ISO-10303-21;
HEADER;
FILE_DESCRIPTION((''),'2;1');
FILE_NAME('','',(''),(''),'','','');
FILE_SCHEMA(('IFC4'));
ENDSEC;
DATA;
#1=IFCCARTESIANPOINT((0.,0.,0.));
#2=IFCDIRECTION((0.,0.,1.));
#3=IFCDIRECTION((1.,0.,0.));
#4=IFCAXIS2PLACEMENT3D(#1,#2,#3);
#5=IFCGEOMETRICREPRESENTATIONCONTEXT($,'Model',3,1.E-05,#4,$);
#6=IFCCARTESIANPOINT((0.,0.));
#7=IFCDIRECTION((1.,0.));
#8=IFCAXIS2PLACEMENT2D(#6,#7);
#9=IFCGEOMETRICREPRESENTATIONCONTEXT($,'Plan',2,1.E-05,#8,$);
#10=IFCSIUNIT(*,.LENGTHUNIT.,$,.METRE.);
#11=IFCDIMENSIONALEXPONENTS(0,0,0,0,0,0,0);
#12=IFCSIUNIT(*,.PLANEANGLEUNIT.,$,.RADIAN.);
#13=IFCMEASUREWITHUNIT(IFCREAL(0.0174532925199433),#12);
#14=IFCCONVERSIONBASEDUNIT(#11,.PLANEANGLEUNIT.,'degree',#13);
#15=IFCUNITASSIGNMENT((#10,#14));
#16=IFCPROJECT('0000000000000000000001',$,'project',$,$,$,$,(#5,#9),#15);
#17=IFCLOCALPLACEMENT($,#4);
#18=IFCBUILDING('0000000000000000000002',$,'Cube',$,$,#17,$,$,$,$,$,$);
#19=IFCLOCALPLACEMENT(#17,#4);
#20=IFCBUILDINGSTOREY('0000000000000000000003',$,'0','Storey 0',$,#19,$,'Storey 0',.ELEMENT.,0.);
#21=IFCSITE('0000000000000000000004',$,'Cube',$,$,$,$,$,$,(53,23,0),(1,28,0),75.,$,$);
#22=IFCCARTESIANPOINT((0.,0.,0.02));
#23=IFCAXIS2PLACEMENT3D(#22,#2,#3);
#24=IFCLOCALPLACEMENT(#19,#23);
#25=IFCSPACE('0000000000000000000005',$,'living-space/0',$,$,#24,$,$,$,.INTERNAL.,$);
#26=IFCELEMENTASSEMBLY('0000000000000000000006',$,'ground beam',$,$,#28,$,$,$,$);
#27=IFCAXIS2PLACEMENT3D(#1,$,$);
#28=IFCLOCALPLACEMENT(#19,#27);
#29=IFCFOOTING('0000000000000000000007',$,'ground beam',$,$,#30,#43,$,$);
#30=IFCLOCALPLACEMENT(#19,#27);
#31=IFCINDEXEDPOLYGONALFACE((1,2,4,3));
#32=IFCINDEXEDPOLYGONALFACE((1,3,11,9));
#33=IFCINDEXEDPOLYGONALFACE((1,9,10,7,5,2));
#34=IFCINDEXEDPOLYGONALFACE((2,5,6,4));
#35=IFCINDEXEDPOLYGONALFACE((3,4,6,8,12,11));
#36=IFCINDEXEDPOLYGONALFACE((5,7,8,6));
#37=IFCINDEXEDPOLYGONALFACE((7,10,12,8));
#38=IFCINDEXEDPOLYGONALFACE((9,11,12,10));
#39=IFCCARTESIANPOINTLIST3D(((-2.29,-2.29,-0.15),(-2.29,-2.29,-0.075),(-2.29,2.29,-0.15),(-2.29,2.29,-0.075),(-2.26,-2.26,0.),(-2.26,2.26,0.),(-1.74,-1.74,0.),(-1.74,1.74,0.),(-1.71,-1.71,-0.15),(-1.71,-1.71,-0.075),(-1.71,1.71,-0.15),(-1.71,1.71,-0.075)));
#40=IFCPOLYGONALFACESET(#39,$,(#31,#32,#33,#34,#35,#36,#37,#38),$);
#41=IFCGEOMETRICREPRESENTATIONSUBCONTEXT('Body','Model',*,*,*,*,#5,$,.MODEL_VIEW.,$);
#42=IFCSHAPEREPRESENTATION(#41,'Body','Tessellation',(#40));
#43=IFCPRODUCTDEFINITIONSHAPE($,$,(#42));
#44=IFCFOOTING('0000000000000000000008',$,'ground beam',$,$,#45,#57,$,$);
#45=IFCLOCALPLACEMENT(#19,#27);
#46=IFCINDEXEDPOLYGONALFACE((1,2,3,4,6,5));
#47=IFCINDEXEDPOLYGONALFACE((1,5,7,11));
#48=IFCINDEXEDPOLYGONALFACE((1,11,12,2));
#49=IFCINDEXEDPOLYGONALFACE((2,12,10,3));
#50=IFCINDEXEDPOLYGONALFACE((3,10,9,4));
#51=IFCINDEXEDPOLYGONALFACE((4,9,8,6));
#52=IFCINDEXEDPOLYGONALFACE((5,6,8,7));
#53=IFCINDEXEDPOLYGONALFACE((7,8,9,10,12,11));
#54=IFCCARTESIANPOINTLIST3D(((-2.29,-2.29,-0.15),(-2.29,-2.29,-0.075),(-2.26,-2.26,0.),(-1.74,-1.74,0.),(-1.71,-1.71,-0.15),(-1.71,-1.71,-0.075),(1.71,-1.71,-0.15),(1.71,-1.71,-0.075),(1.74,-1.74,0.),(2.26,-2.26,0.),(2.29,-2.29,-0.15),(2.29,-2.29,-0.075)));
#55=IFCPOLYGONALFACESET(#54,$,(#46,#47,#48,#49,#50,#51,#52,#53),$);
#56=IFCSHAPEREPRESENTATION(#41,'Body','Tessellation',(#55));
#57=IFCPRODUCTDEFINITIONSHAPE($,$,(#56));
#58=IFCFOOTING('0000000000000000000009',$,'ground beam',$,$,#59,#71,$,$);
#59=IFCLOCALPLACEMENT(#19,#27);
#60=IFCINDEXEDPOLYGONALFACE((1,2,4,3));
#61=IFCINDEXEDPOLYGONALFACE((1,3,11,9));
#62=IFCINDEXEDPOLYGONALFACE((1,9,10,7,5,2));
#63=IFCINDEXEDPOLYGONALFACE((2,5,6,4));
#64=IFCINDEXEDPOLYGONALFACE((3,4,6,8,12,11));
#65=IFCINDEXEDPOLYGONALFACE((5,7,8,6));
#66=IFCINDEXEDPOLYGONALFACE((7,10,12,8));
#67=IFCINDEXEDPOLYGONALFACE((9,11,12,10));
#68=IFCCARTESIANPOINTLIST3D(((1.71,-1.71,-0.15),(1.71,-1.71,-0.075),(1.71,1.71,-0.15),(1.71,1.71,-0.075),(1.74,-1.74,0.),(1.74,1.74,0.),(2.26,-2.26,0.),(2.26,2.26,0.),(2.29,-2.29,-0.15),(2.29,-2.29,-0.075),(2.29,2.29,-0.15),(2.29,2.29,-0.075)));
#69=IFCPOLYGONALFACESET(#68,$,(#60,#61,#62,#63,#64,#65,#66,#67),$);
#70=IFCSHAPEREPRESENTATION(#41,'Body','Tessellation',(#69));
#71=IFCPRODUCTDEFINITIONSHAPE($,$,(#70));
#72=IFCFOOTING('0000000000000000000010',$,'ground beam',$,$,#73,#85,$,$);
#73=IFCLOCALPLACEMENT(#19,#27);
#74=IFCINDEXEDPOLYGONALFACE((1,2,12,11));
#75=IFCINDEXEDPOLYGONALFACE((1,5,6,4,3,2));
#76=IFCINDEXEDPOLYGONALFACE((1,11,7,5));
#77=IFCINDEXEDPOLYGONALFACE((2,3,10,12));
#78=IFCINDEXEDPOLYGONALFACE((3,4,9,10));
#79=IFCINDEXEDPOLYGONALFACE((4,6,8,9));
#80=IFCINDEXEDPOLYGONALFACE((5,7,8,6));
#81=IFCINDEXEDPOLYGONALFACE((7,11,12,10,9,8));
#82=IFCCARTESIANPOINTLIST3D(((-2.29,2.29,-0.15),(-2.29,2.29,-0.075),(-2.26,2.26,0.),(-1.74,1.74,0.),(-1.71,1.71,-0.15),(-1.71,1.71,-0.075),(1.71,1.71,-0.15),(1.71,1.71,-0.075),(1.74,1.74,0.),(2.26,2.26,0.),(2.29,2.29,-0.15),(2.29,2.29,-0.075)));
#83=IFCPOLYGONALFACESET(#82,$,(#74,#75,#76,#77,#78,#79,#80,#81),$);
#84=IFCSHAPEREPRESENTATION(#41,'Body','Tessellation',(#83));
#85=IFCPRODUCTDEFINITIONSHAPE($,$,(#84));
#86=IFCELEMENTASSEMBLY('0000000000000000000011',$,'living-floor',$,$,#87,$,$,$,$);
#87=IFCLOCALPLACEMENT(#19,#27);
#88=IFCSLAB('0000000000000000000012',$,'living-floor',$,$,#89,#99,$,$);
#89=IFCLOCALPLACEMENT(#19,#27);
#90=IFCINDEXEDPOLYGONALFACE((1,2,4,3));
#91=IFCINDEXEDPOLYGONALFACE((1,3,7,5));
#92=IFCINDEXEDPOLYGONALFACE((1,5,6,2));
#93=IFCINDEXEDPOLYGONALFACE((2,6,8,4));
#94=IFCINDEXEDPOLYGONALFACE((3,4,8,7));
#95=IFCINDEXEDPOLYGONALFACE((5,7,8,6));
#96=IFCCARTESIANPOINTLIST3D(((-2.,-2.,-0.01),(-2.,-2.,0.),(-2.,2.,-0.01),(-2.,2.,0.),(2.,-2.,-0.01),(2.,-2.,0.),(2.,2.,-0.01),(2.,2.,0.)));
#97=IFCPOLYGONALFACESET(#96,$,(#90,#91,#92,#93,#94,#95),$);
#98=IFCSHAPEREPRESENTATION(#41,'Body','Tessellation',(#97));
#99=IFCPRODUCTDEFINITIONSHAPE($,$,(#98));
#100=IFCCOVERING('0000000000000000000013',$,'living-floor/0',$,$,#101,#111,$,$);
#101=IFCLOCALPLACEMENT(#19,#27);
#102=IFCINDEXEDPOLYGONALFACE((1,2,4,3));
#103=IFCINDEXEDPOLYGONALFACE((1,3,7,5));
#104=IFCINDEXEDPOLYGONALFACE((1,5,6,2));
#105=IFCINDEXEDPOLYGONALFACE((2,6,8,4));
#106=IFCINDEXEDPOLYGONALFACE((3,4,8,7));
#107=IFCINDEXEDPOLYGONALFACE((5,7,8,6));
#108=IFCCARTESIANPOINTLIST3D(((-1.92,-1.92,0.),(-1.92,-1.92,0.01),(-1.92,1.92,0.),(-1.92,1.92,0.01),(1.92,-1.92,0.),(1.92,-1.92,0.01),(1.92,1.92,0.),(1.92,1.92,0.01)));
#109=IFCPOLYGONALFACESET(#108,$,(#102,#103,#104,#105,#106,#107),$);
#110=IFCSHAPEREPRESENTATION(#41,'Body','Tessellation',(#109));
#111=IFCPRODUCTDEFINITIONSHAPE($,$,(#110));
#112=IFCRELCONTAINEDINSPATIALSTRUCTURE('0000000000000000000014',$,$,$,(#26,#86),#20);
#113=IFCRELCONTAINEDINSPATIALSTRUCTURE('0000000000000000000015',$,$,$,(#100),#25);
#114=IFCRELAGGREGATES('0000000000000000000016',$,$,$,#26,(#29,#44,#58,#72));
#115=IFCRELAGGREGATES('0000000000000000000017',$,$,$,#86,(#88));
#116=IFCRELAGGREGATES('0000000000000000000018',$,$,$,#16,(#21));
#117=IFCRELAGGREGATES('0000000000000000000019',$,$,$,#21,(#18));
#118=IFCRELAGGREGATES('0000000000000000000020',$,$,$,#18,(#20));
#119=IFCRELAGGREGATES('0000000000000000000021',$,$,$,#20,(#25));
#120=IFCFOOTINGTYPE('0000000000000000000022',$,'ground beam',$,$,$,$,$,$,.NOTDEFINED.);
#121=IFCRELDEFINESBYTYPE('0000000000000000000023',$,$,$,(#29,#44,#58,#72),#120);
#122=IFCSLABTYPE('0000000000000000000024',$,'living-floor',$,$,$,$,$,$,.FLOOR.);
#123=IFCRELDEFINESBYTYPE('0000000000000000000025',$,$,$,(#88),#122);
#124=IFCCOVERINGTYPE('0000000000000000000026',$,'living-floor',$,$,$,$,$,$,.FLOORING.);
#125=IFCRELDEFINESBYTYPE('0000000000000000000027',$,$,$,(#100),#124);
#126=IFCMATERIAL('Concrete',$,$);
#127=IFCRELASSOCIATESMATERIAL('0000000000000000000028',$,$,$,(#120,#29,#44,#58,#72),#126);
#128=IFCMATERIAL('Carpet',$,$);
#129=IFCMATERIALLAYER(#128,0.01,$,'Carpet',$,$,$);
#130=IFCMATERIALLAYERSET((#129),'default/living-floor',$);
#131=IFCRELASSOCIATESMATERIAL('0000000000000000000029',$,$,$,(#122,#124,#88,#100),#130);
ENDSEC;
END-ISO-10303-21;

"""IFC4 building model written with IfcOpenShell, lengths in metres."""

from ifc_helpers import new_model, entity, si_unit, converted_unit, frame, origin, origin_with_axes, origin_2d_with_axis, place, context, subcontext, project, spatial, polyline, outline, extrude, clip, halfspace, material, layer, layer_set, layer_usage, material_profile, profile_set, profile_usage, type_object, element, aggregate, save


model = new_model("IFC4")

# Units and contexts
model_context = context("Model", 3, precision=1e-05, world=origin_with_axes())
plan_context = context("Plan", 2, precision=1e-05, world=origin_2d_with_axis())
body_context = subcontext(model_context, "Body", "Model", "MODEL_VIEW")
ifc_project = project(units=[si_unit("LENGTHUNIT", "METRE"), converted_unit("PLANEANGLEUNIT", "degree", entity("IfcReal", 0.0174532925199433), si_unit("PLANEANGLEUNIT", "RADIAN"), dimensions=[0, 0, 0, 0, 0, 0, 0])], contexts=[model_context, plan_context])

# Site, building, storey
site = spatial("IfcSite", under=ifc_project, Name="Cube", RefLatitude=(53, 23, 0), RefLongitude=(1, 28, 0), RefElevation=75.0)
building_placement = place(None, origin_with_axes())
building = spatial("IfcBuilding", under=site, at=building_placement, Name="Cube")
storey_placement = place(building_placement, origin_with_axes())
storey = spatial("IfcBuildingStorey", under=building, at=storey_placement, Name="0", Description="Storey 0", LongName="Storey 0", CompositionType="ELEMENT", Elevation=0.0)

# Element assembly, footings
assembly_1_placement = place(storey_placement, origin_with_axes())
assembly_1 = element("IfcElementAssembly", 1, at=assembly_1_placement, inside=storey, Name="ground beam")
ifc_material_1 = material(Name="Concrete")
ifc_material_profile = material_profile(ifc_material_1, outline(polyline([(-0.26, 0.0), (-0.29, -0.075), (-0.29, -0.15), (0.29, -0.15), (0.29, -0.075), (0.26, 0.0), (-0.26, 0.0)])))
ifc_profile_set = profile_set([ifc_material_profile])
ifc_profile_usage_1 = profile_usage(ifc_profile_set)
footing_type = type_object("IfcFootingType", Name="ground beam", PredefinedType="NOTDEFINED", material=ifc_profile_set)
footing_1_placement = place(assembly_1_placement, frame((-2.0, -3.0, 0.0), z_axis=(0.0, 1.0, 0.0), x_axis=(-1.0, 0.0, 0.0)))
footing_1 = element("IfcFooting", 2, at=footing_1_placement, type_object=footing_type, material=ifc_profile_usage_1, Name="ground beam", context=body_context, shape_type="Clipping", body=[
    clip(clip(extrude(outline(polyline([(-0.26, 0.0), (-0.29, -0.075), (-0.29, -0.15), (0.29, -0.15), (0.29, -0.075), (0.26, 0.0), (-0.26, 0.0)])), origin_with_axes(), (0.0, 0.0, 1.0), 6.0), halfspace(frame((0.0, 0.0, 1.0), z_axis=(-0.707107, 0.0, -0.707107), x_axis=(0.0, 1.0, 0.0)), False)), halfspace(frame((0.0, 0.0, 5.0), z_axis=(-0.707107, 0.0, 0.707107), x_axis=(0.0, 1.0, 0.0)), False)),
])
ifc_profile_usage_2 = profile_usage(ifc_profile_set)
footing_2_placement = place(assembly_1_placement, frame((3.0, -2.0, 0.0), z_axis=(-1.0, 0.0, 0.0), x_axis=(0.0, -1.0, 0.0)))
footing_2 = element("IfcFooting", 3, at=footing_2_placement, type_object=footing_type, material=ifc_profile_usage_2, Name="ground beam", context=body_context, shape_type="Clipping", body=[
    clip(clip(extrude(outline(polyline([(-0.26, 0.0), (-0.29, -0.075), (-0.29, -0.15), (0.29, -0.15), (0.29, -0.075), (0.26, 0.0), (-0.26, 0.0)])), origin_with_axes(), (0.0, 0.0, 1.0), 6.0), halfspace(frame((0.0, 0.0, 1.0), z_axis=(-0.707107, 0.0, -0.707107), x_axis=(0.0, 1.0, 0.0)), False)), halfspace(frame((0.0, 0.0, 5.0), z_axis=(-0.707107, 0.0, 0.707107), x_axis=(0.0, 1.0, 0.0)), False)),
])
ifc_profile_usage_3 = profile_usage(ifc_profile_set)
footing_3_placement = place(assembly_1_placement, frame((2.0, 3.0, 0.0), z_axis=(0.0, -1.0, 0.0), x_axis=(1.0, 0.0, 0.0)))
footing_3 = element("IfcFooting", 4, at=footing_3_placement, type_object=footing_type, material=ifc_profile_usage_3, Name="ground beam", context=body_context, shape_type="Clipping", body=[
    clip(clip(extrude(outline(polyline([(-0.26, 0.0), (-0.29, -0.075), (-0.29, -0.15), (0.29, -0.15), (0.29, -0.075), (0.26, 0.0), (-0.26, 0.0)])), origin_with_axes(), (0.0, 0.0, 1.0), 6.0), halfspace(frame((0.0, 0.0, 1.0), z_axis=(-0.707107, 0.0, -0.707107), x_axis=(0.0, 1.0, 0.0)), False)), halfspace(frame((0.0, 0.0, 5.0), z_axis=(-0.707107, 0.0, 0.707107), x_axis=(0.0, 1.0, 0.0)), False)),
])
ifc_profile_usage_4 = profile_usage(ifc_profile_set)
footing_4_placement = place(assembly_1_placement, frame((-3.0, 2.0, 0.0), z_axis=(1.0, 0.0, 0.0), x_axis=(0.0, 1.0, 0.0)))
footing_4 = element("IfcFooting", 5, at=footing_4_placement, type_object=footing_type, material=ifc_profile_usage_4, Name="ground beam", context=body_context, shape_type="Clipping", body=[
    clip(clip(extrude(outline(polyline([(-0.26, 0.0), (-0.29, -0.075), (-0.29, -0.15), (0.29, -0.15), (0.29, -0.075), (0.26, 0.0), (-0.26, 0.0)])), origin_with_axes(), (0.0, 0.0, 1.0), 6.0), halfspace(frame((0.0, 0.0, 1.0), z_axis=(-0.707107, 0.0, -0.707107), x_axis=(0.0, 1.0, 0.0)), False)), halfspace(frame((0.0, 0.0, 5.0), z_axis=(-0.707107, 0.0, 0.707107), x_axis=(0.0, 1.0, 0.0)), False)),
])
aggregate(assembly_1, [footing_1, footing_2, footing_3, footing_4])

# Element assembly, slab
assembly_2_placement = place(storey_placement, origin_with_axes())
assembly_2 = element("IfcElementAssembly", 6, at=assembly_2_placement, inside=storey, Name="living-floor")
ifc_material_2 = material(Name="Carpet")
ifc_layer = layer(ifc_material_2, 0.01, Name="Carpet")
ifc_layer_set = layer_set([ifc_layer], Name="default/living-floor")
ifc_layer_usage_1 = layer_usage(ifc_layer_set, "AXIS3", "POSITIVE", 0.0)
slab_type = type_object("IfcSlabType", Name="living-floor", PredefinedType="FLOOR", material=ifc_layer_set)
slab_placement = place(assembly_2_placement, frame((2.0, 2.0, -0.01), z_axis=(0.0, 0.0, -1.0), x_axis=(0.0, 1.0, 0.0)))
slab = element("IfcSlab", 7, at=slab_placement, type_object=slab_type, material=ifc_layer_usage_1, Name="living-floor", context=body_context, shape_type="SweptSolid", body=[
    extrude(outline(polyline([(0.0, 0.0), (-4.0, 0.0), (-4.0, -4.0), (0.0, -4.0), (0.0, 0.0)])), origin(), (0.0, 0.0, -1.0), 0.01),
])
aggregate(assembly_2, [slab])

# Shared definitions
space_placement = place(storey_placement, frame((0.0, 0.0, 0.02), z_axis=(0.0, 0.0, 1.0), x_axis=(1.0, 0.0, 0.0)))
space = spatial("IfcSpace", under=storey, at=space_placement, Name="living-space/0", PredefinedType="INTERNAL")

# Covering
ifc_layer_usage_2 = layer_usage(ifc_layer_set, "AXIS3", "POSITIVE", 0.0)
covering_type = type_object("IfcCoveringType", Name="living-floor", PredefinedType="FLOORING", material=ifc_layer_set)
covering_placement = place(space_placement, frame((0.0, 0.0, -0.02), z_axis=(0.0, 0.0, 1.0), x_axis=(1.0, 0.0, 0.0)))
element("IfcCovering", 8, at=covering_placement, inside=space, type_object=covering_type, material=ifc_layer_usage_2, Name="living-floor/0", context=body_context, shape_type="SweptSolid", body=[
    extrude(outline(polyline([(1.92, 1.92), (-1.92, 1.92), (-1.92, -1.92), (1.92, -1.92), (1.92, 1.92)])), origin_with_axes(), (0.0, 0.0, 1.0), 0.01),
])

save(model, "model.ifc")
